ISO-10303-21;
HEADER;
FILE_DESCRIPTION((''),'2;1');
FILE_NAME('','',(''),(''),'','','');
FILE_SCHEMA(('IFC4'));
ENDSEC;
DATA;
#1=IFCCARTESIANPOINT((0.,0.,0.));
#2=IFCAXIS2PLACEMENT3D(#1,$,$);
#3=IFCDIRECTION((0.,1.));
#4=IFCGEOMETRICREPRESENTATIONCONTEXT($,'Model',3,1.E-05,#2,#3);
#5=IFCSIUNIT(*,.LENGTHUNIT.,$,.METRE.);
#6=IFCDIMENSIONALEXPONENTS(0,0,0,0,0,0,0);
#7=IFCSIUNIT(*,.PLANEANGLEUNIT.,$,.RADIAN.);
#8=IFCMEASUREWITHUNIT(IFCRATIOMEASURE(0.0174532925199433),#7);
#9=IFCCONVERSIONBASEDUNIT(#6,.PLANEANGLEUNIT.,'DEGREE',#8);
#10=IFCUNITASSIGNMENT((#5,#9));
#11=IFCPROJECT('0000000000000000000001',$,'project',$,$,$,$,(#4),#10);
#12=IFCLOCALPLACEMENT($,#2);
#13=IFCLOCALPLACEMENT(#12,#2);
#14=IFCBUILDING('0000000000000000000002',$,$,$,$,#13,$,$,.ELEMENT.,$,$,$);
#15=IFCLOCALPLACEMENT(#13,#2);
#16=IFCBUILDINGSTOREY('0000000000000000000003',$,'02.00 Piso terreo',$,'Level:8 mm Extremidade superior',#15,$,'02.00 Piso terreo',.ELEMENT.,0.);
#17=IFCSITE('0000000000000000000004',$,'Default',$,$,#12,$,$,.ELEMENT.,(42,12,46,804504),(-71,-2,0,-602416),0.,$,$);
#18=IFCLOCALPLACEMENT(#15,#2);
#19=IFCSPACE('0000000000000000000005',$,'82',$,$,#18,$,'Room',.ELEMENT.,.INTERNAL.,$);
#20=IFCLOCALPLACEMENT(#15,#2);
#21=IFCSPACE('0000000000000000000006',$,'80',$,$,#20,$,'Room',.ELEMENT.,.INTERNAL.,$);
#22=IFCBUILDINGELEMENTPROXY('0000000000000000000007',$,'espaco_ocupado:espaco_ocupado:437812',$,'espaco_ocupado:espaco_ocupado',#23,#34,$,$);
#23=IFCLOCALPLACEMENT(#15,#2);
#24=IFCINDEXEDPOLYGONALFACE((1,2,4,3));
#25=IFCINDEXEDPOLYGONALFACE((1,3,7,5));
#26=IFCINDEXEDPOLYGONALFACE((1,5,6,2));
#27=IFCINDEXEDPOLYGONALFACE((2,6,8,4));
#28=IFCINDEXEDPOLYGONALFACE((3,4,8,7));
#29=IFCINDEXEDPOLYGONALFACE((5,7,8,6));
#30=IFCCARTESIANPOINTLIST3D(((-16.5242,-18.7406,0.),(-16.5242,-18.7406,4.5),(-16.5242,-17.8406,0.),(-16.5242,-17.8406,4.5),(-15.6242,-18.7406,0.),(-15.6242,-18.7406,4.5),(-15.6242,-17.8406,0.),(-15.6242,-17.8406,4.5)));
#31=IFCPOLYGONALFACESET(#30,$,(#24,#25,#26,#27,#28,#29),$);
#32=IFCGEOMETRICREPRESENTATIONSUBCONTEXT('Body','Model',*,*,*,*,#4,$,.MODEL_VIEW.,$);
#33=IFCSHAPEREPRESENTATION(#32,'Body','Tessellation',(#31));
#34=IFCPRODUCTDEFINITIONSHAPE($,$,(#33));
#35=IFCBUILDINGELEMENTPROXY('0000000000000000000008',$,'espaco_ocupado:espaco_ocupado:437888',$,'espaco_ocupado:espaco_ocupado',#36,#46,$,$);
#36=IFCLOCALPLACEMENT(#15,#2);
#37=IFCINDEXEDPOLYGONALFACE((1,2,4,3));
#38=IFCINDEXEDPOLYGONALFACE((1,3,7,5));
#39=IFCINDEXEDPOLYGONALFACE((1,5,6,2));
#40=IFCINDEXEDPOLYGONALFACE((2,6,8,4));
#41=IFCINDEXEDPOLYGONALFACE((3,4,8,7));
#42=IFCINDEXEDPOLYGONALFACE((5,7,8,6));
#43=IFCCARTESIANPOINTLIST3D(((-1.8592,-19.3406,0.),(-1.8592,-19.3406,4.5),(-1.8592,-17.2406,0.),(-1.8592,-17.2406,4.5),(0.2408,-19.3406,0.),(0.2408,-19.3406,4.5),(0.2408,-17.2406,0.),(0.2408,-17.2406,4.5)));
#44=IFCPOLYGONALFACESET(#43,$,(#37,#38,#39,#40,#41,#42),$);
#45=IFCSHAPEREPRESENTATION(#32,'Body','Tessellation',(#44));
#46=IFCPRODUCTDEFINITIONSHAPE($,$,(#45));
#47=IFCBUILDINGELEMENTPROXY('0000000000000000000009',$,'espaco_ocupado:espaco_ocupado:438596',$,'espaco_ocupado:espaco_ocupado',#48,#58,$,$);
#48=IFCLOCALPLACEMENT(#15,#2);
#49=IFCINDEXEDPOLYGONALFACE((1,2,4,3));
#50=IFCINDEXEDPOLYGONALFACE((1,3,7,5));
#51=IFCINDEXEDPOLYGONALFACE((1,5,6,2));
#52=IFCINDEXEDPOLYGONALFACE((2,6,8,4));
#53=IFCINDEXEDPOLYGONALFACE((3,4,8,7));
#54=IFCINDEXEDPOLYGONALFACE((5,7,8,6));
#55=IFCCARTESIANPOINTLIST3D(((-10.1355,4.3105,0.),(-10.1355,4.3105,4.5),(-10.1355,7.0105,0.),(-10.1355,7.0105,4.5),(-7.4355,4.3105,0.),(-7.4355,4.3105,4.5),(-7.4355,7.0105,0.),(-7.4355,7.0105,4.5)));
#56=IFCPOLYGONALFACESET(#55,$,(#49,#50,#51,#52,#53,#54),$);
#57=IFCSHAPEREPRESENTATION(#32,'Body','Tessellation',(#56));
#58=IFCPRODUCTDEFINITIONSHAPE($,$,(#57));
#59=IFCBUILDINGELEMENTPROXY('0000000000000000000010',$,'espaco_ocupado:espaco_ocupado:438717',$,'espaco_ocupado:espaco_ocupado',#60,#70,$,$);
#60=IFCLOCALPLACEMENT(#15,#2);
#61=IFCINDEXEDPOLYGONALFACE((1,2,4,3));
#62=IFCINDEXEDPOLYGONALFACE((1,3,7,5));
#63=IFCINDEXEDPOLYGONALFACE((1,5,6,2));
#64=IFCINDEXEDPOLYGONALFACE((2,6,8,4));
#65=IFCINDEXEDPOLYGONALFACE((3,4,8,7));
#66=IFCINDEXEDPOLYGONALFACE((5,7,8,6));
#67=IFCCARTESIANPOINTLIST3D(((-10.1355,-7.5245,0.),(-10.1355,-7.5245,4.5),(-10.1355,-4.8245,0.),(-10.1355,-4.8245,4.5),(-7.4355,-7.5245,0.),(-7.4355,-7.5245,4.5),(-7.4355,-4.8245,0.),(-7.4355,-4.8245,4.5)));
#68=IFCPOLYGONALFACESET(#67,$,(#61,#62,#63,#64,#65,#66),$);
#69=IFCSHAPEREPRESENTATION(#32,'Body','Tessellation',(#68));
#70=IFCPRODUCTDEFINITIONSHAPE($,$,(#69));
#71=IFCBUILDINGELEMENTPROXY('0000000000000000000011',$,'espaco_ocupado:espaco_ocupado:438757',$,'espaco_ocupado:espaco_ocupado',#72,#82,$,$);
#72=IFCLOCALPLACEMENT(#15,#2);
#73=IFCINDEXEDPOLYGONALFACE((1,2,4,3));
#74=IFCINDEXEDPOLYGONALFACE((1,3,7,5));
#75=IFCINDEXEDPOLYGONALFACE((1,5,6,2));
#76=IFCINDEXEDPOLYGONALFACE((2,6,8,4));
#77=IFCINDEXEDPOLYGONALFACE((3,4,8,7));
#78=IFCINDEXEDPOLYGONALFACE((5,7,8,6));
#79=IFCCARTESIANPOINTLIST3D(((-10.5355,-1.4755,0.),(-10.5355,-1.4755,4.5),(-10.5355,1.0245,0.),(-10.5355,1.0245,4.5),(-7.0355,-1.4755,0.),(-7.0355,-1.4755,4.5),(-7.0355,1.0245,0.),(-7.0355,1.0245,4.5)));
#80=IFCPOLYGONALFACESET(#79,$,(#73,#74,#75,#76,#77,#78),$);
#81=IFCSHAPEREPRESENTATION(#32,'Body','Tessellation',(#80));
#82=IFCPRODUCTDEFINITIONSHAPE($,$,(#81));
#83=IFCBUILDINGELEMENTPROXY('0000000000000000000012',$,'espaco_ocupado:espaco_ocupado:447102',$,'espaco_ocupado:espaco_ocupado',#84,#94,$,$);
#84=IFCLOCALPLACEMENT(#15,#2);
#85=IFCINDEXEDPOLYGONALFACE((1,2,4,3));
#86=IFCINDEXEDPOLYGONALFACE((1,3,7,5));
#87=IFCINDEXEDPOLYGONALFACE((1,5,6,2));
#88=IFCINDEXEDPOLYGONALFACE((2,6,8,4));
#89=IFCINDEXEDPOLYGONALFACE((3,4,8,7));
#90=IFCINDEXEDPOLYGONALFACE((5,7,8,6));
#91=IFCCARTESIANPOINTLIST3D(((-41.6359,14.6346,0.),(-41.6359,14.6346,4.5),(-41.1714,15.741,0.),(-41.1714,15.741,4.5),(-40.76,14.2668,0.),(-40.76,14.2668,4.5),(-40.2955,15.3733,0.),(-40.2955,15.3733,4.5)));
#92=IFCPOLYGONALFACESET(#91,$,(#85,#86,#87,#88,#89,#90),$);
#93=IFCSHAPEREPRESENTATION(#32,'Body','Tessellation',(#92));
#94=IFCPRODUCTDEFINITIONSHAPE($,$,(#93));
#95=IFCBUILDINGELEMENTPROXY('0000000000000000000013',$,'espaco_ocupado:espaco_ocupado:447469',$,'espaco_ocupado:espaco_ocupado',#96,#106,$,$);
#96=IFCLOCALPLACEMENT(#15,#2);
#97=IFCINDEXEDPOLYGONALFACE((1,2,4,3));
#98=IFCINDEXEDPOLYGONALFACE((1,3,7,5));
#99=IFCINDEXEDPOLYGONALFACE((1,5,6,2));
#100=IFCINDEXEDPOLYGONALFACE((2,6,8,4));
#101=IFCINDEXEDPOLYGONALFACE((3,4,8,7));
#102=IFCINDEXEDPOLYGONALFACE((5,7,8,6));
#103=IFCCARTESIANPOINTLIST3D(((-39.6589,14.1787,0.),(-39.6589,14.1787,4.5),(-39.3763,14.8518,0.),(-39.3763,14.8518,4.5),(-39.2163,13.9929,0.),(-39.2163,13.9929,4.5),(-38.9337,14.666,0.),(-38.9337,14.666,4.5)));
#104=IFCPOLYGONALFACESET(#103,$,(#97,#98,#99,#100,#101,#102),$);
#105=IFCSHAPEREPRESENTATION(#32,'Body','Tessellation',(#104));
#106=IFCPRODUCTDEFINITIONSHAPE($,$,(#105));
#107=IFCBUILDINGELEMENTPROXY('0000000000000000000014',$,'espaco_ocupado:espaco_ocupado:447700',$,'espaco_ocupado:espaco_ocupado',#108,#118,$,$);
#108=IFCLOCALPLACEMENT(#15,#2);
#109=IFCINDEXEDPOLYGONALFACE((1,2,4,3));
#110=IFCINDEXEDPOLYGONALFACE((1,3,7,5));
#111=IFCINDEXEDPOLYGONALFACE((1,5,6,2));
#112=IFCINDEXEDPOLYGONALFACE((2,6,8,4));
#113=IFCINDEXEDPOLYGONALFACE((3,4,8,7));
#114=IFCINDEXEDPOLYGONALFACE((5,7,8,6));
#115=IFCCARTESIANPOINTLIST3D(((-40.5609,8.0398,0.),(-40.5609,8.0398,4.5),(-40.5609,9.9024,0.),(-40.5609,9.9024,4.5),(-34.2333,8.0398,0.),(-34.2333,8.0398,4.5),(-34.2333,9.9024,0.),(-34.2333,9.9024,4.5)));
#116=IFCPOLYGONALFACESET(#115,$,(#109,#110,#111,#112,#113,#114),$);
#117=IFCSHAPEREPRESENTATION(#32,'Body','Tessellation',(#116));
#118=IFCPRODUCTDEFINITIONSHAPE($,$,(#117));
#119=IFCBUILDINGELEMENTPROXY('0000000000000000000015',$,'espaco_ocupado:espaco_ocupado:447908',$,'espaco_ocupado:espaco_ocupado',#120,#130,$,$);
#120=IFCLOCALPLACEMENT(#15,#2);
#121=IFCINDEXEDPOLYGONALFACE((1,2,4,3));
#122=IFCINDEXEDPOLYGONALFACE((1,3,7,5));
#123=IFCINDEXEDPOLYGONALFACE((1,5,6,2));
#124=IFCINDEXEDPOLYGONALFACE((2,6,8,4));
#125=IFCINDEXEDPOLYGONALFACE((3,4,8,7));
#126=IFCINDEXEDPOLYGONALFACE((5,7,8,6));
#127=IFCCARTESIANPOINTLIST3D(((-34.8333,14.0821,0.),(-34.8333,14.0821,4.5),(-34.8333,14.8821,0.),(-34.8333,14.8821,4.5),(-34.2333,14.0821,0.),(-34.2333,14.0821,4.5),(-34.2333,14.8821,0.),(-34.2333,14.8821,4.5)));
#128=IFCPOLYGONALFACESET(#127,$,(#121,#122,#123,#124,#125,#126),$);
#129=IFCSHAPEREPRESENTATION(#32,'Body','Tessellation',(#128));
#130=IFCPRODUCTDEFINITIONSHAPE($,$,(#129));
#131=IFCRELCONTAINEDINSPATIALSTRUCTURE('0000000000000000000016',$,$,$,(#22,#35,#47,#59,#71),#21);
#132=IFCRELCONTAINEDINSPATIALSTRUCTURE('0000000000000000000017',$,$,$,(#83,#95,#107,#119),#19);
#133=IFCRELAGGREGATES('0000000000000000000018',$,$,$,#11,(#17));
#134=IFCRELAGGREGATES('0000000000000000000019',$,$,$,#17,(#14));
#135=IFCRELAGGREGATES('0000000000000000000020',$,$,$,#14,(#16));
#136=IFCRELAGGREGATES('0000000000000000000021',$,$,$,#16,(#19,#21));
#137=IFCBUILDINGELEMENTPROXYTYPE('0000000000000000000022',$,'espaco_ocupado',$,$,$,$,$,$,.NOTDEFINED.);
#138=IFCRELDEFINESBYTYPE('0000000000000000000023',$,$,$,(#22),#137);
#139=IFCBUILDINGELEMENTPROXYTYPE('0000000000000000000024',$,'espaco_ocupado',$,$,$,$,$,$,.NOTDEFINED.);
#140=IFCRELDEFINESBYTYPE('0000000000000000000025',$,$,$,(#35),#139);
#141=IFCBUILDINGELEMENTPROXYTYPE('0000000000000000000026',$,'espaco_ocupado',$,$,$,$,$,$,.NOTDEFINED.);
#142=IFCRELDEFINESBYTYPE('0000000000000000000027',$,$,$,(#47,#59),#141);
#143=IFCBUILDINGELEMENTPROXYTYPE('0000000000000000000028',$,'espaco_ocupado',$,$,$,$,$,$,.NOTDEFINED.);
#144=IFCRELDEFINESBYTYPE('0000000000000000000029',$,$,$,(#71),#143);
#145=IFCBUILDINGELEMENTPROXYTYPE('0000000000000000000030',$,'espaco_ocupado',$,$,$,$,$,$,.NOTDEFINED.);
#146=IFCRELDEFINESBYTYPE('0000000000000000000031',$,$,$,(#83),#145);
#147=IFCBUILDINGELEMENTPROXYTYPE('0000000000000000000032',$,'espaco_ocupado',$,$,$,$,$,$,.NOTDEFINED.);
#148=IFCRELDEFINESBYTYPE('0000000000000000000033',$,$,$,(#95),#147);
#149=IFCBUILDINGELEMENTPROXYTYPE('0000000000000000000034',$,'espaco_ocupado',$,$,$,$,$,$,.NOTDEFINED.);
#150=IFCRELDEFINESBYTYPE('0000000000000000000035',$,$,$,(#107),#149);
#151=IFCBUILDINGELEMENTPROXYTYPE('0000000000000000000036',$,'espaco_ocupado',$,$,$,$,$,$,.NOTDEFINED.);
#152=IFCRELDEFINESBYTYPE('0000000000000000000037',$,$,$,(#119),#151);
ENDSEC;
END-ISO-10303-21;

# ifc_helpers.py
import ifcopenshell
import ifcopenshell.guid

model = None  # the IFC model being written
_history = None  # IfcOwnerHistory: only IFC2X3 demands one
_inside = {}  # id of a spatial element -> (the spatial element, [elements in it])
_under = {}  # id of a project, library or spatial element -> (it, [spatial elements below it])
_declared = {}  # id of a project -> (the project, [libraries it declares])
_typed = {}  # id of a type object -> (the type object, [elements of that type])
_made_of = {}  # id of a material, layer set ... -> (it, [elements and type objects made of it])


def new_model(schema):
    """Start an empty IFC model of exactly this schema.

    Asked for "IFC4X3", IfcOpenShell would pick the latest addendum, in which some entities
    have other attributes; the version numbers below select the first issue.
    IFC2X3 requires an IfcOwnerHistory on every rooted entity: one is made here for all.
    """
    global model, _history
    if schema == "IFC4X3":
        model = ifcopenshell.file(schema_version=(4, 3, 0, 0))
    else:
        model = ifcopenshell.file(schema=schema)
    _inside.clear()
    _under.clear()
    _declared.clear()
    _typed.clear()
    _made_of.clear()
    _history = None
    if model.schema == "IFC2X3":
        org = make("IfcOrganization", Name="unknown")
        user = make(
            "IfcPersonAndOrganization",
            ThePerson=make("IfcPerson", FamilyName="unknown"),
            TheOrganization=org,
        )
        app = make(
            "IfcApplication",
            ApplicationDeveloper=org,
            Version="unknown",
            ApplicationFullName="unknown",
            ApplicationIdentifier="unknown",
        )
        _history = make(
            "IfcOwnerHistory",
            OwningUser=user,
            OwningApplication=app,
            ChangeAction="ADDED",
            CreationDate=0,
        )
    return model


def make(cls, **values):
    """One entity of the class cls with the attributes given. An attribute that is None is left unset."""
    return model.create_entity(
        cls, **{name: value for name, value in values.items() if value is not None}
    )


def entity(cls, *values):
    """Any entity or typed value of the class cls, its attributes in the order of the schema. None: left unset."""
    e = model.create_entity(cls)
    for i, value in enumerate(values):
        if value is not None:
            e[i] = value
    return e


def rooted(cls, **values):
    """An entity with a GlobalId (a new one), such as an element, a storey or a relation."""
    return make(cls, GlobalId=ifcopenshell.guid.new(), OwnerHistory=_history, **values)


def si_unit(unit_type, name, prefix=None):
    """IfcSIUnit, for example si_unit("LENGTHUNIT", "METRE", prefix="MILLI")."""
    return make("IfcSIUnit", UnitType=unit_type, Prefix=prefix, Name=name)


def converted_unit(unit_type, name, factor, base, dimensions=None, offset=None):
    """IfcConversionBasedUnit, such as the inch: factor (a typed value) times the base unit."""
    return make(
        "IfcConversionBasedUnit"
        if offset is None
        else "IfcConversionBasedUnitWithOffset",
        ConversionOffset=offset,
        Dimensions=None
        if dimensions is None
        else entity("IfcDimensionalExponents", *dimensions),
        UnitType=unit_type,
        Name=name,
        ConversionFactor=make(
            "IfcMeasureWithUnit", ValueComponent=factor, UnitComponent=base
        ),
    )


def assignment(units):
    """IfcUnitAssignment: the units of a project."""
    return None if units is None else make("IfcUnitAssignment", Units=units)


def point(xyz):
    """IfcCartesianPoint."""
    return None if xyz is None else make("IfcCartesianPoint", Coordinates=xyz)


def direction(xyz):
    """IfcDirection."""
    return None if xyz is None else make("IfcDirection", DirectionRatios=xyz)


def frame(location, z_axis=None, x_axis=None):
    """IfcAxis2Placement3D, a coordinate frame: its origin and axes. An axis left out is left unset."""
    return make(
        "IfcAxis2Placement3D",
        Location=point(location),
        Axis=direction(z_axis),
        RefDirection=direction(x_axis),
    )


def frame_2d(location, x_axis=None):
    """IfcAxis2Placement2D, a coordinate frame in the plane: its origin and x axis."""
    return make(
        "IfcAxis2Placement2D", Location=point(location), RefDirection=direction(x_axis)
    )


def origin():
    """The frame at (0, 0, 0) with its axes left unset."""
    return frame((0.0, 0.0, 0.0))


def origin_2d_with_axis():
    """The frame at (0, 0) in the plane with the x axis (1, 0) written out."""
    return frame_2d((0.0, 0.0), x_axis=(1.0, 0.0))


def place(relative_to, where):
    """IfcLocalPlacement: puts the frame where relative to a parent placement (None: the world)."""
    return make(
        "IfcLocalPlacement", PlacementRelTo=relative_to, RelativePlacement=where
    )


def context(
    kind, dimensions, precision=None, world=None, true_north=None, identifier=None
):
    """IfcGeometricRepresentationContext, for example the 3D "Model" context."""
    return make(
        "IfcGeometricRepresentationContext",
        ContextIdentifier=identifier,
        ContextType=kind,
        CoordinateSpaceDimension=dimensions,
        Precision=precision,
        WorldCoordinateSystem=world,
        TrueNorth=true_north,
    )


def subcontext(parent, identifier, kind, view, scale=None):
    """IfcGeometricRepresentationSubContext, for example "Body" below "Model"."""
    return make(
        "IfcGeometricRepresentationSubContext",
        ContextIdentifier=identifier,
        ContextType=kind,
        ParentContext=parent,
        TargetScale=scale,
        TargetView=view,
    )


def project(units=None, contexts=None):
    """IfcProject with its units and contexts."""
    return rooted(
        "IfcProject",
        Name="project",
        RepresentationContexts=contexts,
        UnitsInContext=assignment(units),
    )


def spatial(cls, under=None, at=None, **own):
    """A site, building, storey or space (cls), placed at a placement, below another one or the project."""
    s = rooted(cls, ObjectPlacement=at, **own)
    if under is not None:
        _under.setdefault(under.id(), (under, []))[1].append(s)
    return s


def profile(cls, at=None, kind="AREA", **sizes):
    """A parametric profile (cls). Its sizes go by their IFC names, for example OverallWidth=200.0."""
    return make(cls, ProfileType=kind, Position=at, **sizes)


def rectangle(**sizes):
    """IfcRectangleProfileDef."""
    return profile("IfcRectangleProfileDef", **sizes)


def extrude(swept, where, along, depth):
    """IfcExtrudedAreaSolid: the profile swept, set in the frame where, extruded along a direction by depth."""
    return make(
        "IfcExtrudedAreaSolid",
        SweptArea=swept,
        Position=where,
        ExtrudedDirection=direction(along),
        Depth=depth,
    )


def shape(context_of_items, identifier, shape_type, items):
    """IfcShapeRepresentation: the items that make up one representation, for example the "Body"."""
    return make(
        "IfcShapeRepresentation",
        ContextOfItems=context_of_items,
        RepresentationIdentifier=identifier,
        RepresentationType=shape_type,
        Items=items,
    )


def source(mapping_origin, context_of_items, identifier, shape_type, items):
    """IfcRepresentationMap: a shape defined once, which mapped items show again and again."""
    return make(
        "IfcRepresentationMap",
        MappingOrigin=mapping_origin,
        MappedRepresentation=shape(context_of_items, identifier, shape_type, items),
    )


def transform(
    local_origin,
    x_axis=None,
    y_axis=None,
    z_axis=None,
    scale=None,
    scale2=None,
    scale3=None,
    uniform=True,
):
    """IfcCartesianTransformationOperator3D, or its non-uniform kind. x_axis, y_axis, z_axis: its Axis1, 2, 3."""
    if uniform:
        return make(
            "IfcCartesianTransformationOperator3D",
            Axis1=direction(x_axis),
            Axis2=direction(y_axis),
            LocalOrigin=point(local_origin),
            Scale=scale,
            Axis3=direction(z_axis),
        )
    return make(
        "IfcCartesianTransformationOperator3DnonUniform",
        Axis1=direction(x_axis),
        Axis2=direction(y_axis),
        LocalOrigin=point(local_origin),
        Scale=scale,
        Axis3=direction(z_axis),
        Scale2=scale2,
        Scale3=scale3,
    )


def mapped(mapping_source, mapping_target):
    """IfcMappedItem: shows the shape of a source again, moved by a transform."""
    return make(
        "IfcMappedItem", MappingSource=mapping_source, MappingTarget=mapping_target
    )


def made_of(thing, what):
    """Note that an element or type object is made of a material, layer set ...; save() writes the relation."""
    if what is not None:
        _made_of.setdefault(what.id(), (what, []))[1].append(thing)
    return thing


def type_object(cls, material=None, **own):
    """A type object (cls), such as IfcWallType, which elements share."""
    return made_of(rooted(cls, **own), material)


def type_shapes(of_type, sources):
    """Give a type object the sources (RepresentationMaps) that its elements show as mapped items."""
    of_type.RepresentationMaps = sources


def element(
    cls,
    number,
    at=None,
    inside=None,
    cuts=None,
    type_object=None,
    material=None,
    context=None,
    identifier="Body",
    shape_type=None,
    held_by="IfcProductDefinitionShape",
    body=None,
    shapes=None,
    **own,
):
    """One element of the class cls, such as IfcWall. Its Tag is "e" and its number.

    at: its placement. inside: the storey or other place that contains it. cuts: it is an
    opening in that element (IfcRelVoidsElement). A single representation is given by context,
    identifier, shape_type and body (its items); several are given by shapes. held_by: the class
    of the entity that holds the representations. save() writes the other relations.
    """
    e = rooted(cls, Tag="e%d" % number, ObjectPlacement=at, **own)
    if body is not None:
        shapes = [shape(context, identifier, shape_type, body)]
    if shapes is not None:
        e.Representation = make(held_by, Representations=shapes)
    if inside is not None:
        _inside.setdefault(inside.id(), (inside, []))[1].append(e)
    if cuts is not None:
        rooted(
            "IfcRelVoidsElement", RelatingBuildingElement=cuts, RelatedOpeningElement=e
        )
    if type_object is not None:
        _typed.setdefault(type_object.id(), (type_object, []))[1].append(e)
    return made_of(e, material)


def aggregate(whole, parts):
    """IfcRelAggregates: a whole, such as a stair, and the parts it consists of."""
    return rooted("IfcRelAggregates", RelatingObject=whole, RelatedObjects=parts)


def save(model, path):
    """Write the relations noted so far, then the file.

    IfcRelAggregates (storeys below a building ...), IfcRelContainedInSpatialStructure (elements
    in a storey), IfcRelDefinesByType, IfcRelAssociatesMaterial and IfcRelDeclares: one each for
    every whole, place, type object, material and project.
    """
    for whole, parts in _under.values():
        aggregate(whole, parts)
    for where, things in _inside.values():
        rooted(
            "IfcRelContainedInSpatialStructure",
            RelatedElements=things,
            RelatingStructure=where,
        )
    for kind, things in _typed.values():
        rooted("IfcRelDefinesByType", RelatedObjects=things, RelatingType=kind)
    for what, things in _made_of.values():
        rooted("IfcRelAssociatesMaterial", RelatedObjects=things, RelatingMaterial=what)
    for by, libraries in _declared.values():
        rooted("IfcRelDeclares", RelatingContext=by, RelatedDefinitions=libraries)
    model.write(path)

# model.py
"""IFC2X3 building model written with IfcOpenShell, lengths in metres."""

from ifc_helpers import new_model, entity, si_unit, converted_unit, direction, frame, frame_2d, origin, origin_2d_with_axis, place, context, subcontext, project, spatial, rectangle, extrude, source, transform, mapped, type_object, type_shapes, element, save


model = new_model("IFC2X3")

# Units and contexts
model_context = context("Model", 3, precision=1e-05, world=origin(), true_north=direction((0.0, 1.0)))
body_context = subcontext(model_context, "Body", "Model", "MODEL_VIEW")
ifc_project = project(units=[si_unit("LENGTHUNIT", "METRE"), converted_unit("PLANEANGLEUNIT", "DEGREE", entity("IfcRatioMeasure", 0.0174532925199433), si_unit("PLANEANGLEUNIT", "RADIAN"), dimensions=[0, 0, 0, 0, 0, 0, 0])], contexts=[model_context])

# Site, building, storey, space
site_placement = place(None, origin())
site = spatial("IfcSite", under=ifc_project, at=site_placement, Name="Default", CompositionType="ELEMENT", RefLatitude=(42, 12, 46, 804504), RefLongitude=(-71, -2, 0, -602416), RefElevation=0.0)
building_placement = place(site_placement, origin())
building = spatial("IfcBuilding", under=site, at=building_placement, CompositionType="ELEMENT")
storey_placement = place(building_placement, origin())
storey = spatial("IfcBuildingStorey", under=building, at=storey_placement, Name="02.00 Piso terreo", ObjectType="Level:8 mm Extremidade superior", LongName="02.00 Piso terreo", CompositionType="ELEMENT", Elevation=0.0)
space_1_placement = place(storey_placement, origin())
space_1 = spatial("IfcSpace", under=storey, at=space_1_placement, Name="82", LongName="Room", CompositionType="ELEMENT", InteriorOrExteriorSpace="INTERNAL")

# Shared definitions
space_2_placement = place(storey_placement, origin())
space_2 = spatial("IfcSpace", under=storey, at=space_2_placement, Name="80", LongName="Room", CompositionType="ELEMENT", InteriorOrExteriorSpace="INTERNAL")

# Building element proxies
building_element_proxy_type_1 = type_object("IfcBuildingElementProxyType", Name="espaco_ocupado", PredefinedType="NOTDEFINED")
shared_shape_1 = source(origin(), body_context, "Body", "SweptSolid", [
    extrude(rectangle(XDim=0.9, YDim=0.9, at=origin_2d_with_axis()), frame((0.0, 0.0, 0.0), z_axis=(0.0, 0.0, 1.0), x_axis=(-1.0, 0.0, 0.0)), (0.0, 0.0, 1.0), 4.5),
])
type_shapes(building_element_proxy_type_1, [shared_shape_1])
proxy_1_placement = place(space_2_placement, frame((-16.0742, -18.2906, 0.0)))
element("IfcBuildingElementProxy", 1, at=proxy_1_placement, inside=space_2, type_object=building_element_proxy_type_1, Name="espaco_ocupado:espaco_ocupado:437812", ObjectType="espaco_ocupado:espaco_ocupado", context=body_context, shape_type="MappedRepresentation", body=[
    mapped(shared_shape_1, transform((0.0, 0.0, 0.0), scale=1.0)),
])
building_element_proxy_type_2 = type_object("IfcBuildingElementProxyType", Name="espaco_ocupado", PredefinedType="NOTDEFINED")
shared_shape_2 = source(origin(), body_context, "Body", "SweptSolid", [
    extrude(rectangle(XDim=2.1, YDim=2.1, at=frame_2d((0.0, 0.0), x_axis=(1.0, 0.0))), frame((0.0, 0.0, 0.0), z_axis=(0.0, 0.0, 1.0), x_axis=(-1.0, 0.0, 0.0)), (0.0, 0.0, 1.0), 4.5),
])
type_shapes(building_element_proxy_type_2, [shared_shape_2])
proxy_2_placement = place(space_2_placement, frame((-0.8092, -18.2906, 0.0)))
element("IfcBuildingElementProxy", 2, at=proxy_2_placement, inside=space_2, type_object=building_element_proxy_type_2, Name="espaco_ocupado:espaco_ocupado:437888", ObjectType="espaco_ocupado:espaco_ocupado", context=body_context, shape_type="MappedRepresentation", body=[
    mapped(shared_shape_2, transform((0.0, 0.0, 0.0), scale=1.0)),
])
building_element_proxy_type_3 = type_object("IfcBuildingElementProxyType", Name="espaco_ocupado", PredefinedType="NOTDEFINED")
shared_shape_3 = source(origin(), body_context, "Body", "SweptSolid", [
    extrude(rectangle(XDim=2.7, YDim=2.7, at=frame_2d((0.0, 0.0), x_axis=(1.0, 0.0))), frame((0.0, 0.0, 0.0), z_axis=(0.0, 0.0, 1.0), x_axis=(-1.0, 0.0, 0.0)), (0.0, 0.0, 1.0), 4.5),
])
type_shapes(building_element_proxy_type_3, [shared_shape_3])
for number, where, name in (
    (3, (-8.7855, 5.6605, 0.0), "espaco_ocupado:espaco_ocupado:438596"),
    (4, (-8.7855, -6.1745, 0.0), "espaco_ocupado:espaco_ocupado:438717"),
):
    element("IfcBuildingElementProxy", number, at=place(space_2_placement, frame(where)), inside=space_2, type_object=building_element_proxy_type_3, Name=name, ObjectType="espaco_ocupado:espaco_ocupado", context=body_context, shape_type="MappedRepresentation", body=[
        mapped(shared_shape_3, transform((0.0, 0.0, 0.0), scale=1.0)),
    ])
building_element_proxy_type_4 = type_object("IfcBuildingElementProxyType", Name="espaco_ocupado", PredefinedType="NOTDEFINED")
shared_shape_4 = source(origin(), body_context, "Body", "SweptSolid", [
    extrude(rectangle(XDim=3.5, YDim=2.5, at=origin_2d_with_axis()), frame((0.0, 0.0, 0.0), z_axis=(0.0, 0.0, 1.0), x_axis=(-1.0, 0.0, 0.0)), (0.0, 0.0, 1.0), 4.5),
])
type_shapes(building_element_proxy_type_4, [shared_shape_4])
proxy_3_placement = place(space_2_placement, frame((-8.7855, -0.2255, 0.0)))
element("IfcBuildingElementProxy", 5, at=proxy_3_placement, inside=space_2, type_object=building_element_proxy_type_4, Name="espaco_ocupado:espaco_ocupado:438757", ObjectType="espaco_ocupado:espaco_ocupado", context=body_context, shape_type="MappedRepresentation", body=[
    mapped(shared_shape_4, transform((0.0, 0.0, 0.0), scale=1.0)),
])
building_element_proxy_type_5 = type_object("IfcBuildingElementProxyType", Name="espaco_ocupado", PredefinedType="NOTDEFINED")
shared_shape_5 = source(origin(), body_context, "Body", "SweptSolid", [
    extrude(rectangle(XDim=1.2, YDim=0.95, at=origin_2d_with_axis()), frame((0.0, 0.0, 0.0), z_axis=(0.0, 0.0, 1.0), x_axis=(-1.0, 0.0, 0.0)), (0.0, 0.0, 1.0), 4.5),
])
type_shapes(building_element_proxy_type_5, [shared_shape_5])
proxy_4_placement = place(space_1_placement, frame((-40.9657, 15.0039, 0.0), z_axis=(0.0, 0.0, 1.0), x_axis=(0.387097, 0.922039, 0.0)))
element("IfcBuildingElementProxy", 6, at=proxy_4_placement, inside=space_1, type_object=building_element_proxy_type_5, Name="espaco_ocupado:espaco_ocupado:447102", ObjectType="espaco_ocupado:espaco_ocupado", context=body_context, shape_type="MappedRepresentation", body=[
    mapped(shared_shape_5, transform((0.0, 0.0, 0.0), scale=1.0)),
])
building_element_proxy_type_6 = type_object("IfcBuildingElementProxyType", Name="espaco_ocupado", PredefinedType="NOTDEFINED")
shared_shape_6 = source(origin(), body_context, "Body", "SweptSolid", [
    extrude(rectangle(XDim=0.73, YDim=0.48, at=origin_2d_with_axis()), frame((0.0, 0.0, 0.0), z_axis=(0.0, 0.0, 1.0), x_axis=(-1.0, 0.0, 0.0)), (0.0, 0.0, 1.0), 4.5),
])
type_shapes(building_element_proxy_type_6, [shared_shape_6])
proxy_5_placement = place(space_1_placement, frame((-39.2963, 14.4223, 0.0), z_axis=(0.0, 0.0, 1.0), x_axis=(0.387097, 0.922039, 0.0)))
element("IfcBuildingElementProxy", 7, at=proxy_5_placement, inside=space_1, type_object=building_element_proxy_type_6, Name="espaco_ocupado:espaco_ocupado:447469", ObjectType="espaco_ocupado:espaco_ocupado", context=body_context, shape_type="MappedRepresentation", body=[
    mapped(shared_shape_6, transform((0.0, 0.0, 0.0), scale=1.0)),
])
building_element_proxy_type_7 = type_object("IfcBuildingElementProxyType", Name="espaco_ocupado", PredefinedType="NOTDEFINED")
shared_shape_7 = source(origin(), body_context, "Body", "SweptSolid", [
    extrude(rectangle(XDim=6.3276, YDim=1.8626, at=origin_2d_with_axis()), frame((0.0, 0.0, 0.0), z_axis=(0.0, 0.0, 1.0), x_axis=(-1.0, 0.0, 0.0)), (0.0, 0.0, 1.0), 4.5),
])
type_shapes(building_element_proxy_type_7, [shared_shape_7])
proxy_6_placement = place(space_1_placement, frame((-37.3971, 8.9711, 0.0)))
element("IfcBuildingElementProxy", 8, at=proxy_6_placement, inside=space_1, type_object=building_element_proxy_type_7, Name="espaco_ocupado:espaco_ocupado:447700", ObjectType="espaco_ocupado:espaco_ocupado", context=body_context, shape_type="MappedRepresentation", body=[
    mapped(shared_shape_7, transform((0.0, 0.0, 0.0), scale=1.0)),
])
building_element_proxy_type_8 = type_object("IfcBuildingElementProxyType", Name="espaco_ocupado", PredefinedType="NOTDEFINED")
shared_shape_8 = source(origin(), body_context, "Body", "SweptSolid", [
    extrude(rectangle(XDim=0.6, YDim=0.8, at=origin_2d_with_axis()), frame((0.0, 0.0, 0.0), z_axis=(0.0, 0.0, 1.0), x_axis=(-1.0, 0.0, 0.0)), (0.0, 0.0, 1.0), 4.5),
])
type_shapes(building_element_proxy_type_8, [shared_shape_8])
proxy_7_placement = place(space_1_placement, frame((-34.5333, 14.4821, 0.0)))
element("IfcBuildingElementProxy", 9, at=proxy_7_placement, inside=space_1, type_object=building_element_proxy_type_8, Name="espaco_ocupado:espaco_ocupado:447908", ObjectType="espaco_ocupado:espaco_ocupado", context=body_context, shape_type="MappedRepresentation", body=[
    mapped(shared_shape_8, transform((0.0, 0.0, 0.0), scale=1.0)),
])

save(model, "model.ifc")
